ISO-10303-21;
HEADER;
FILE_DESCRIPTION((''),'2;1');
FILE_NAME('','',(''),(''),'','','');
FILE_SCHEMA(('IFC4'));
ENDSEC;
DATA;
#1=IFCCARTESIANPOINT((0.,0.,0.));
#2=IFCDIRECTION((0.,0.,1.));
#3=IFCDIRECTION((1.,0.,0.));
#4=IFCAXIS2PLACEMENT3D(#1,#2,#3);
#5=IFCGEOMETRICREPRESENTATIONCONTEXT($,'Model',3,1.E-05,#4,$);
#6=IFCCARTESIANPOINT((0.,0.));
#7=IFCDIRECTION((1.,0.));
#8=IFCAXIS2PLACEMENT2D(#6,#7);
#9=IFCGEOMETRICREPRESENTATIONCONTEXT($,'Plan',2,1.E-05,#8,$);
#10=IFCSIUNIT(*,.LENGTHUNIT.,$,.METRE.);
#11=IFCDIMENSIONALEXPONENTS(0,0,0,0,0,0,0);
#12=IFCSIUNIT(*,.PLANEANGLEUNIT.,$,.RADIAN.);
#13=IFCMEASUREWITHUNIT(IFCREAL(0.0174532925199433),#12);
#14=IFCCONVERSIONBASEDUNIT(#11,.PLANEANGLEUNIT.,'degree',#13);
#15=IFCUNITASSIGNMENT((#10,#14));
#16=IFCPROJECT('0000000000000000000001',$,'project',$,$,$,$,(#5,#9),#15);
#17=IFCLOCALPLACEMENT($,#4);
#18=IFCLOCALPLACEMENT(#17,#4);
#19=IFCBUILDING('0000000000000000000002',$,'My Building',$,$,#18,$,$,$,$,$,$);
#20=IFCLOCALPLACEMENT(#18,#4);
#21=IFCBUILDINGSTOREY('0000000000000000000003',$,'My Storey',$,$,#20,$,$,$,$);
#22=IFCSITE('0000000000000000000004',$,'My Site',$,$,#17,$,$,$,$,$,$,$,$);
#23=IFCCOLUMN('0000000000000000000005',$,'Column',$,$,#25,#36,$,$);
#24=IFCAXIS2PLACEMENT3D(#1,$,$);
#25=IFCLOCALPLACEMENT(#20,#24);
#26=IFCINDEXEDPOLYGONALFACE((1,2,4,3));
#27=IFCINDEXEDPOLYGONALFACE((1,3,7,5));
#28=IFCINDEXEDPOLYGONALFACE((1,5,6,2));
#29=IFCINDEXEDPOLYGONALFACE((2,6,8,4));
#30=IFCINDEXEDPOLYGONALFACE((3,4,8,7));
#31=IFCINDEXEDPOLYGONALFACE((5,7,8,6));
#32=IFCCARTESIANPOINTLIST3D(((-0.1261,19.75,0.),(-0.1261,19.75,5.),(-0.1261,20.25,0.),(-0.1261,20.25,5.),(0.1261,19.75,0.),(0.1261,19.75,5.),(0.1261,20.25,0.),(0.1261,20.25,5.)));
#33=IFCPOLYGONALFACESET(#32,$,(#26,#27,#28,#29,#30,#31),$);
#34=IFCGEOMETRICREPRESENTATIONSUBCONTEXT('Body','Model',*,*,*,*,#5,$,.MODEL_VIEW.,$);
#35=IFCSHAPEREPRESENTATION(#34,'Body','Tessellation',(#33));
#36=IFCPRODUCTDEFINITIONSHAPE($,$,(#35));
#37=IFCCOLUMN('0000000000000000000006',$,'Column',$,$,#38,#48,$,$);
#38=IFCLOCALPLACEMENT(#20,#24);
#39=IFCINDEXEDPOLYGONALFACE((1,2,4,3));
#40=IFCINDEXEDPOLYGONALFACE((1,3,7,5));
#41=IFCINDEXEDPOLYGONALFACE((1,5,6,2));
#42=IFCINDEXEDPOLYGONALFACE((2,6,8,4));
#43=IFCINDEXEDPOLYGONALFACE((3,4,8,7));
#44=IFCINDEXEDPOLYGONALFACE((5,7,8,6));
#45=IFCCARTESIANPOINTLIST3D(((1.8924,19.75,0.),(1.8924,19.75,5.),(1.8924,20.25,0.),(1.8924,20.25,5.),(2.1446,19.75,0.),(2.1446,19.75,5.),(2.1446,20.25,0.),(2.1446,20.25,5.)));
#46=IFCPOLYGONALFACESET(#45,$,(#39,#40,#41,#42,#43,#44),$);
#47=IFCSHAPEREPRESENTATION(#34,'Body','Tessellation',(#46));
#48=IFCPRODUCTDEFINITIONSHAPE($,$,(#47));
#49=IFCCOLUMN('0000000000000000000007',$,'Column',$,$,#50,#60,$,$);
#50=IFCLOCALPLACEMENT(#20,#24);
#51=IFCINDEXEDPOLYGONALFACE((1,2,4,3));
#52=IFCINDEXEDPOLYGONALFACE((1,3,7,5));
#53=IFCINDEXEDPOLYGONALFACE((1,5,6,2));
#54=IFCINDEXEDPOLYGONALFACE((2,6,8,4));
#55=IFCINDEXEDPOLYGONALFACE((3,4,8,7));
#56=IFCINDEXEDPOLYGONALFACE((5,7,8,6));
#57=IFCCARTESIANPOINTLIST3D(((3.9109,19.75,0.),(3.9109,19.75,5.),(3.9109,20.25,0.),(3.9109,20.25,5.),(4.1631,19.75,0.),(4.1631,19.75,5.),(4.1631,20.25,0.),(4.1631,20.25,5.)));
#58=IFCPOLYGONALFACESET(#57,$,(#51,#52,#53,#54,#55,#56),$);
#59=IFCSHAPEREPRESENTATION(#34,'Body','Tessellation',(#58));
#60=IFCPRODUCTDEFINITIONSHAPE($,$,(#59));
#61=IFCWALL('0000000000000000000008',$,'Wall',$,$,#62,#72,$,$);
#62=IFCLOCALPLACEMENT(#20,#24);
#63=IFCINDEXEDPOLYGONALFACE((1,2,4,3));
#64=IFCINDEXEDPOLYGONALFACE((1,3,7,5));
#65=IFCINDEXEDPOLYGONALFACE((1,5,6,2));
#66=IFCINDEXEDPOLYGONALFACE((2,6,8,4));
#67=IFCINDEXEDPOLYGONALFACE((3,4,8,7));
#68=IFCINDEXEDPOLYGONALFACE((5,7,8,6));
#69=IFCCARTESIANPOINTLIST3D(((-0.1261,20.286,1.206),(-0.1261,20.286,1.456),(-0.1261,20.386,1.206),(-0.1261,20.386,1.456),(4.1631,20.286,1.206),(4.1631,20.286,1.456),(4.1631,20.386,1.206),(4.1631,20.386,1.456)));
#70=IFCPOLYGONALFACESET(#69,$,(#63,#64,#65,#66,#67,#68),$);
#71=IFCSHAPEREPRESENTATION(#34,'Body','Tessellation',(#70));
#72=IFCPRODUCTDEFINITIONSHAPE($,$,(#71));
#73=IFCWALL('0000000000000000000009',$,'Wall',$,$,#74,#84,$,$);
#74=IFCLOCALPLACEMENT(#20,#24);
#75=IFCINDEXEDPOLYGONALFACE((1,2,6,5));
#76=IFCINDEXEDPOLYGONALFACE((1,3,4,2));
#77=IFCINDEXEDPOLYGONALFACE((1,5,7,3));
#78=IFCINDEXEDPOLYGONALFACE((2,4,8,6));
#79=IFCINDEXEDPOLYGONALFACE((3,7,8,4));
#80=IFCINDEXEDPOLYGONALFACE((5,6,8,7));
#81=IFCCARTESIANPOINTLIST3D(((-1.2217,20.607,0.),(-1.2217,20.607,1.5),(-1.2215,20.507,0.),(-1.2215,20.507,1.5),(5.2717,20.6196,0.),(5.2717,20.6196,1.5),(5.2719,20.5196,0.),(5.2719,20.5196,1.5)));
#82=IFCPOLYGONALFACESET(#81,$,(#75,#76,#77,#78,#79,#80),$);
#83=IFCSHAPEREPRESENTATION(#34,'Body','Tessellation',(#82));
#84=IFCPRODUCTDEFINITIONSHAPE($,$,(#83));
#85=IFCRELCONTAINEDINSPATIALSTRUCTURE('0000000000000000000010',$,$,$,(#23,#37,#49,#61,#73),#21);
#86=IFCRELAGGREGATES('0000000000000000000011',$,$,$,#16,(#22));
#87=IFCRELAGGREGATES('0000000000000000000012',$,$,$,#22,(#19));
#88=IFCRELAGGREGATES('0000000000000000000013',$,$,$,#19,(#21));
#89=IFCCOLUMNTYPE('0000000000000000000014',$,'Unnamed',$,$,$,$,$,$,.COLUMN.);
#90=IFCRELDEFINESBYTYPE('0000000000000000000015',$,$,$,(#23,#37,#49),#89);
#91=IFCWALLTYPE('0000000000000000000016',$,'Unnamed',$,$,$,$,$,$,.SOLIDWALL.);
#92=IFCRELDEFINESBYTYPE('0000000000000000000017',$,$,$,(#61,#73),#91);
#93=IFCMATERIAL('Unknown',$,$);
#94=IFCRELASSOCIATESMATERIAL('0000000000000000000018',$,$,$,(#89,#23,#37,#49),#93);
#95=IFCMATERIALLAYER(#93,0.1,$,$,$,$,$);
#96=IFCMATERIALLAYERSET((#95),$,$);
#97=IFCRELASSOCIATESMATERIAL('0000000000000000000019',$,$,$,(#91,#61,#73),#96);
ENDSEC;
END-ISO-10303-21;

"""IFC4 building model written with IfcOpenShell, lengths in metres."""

from ifc_helpers import new_model, entity, si_unit, converted_unit, frame, origin_with_axes, origin_2d_with_axis, place, context, subcontext, project, spatial, line, indexed_curve, outline, extrude, material, layer, layer_set, layer_usage, material_profile, profile_set, profile_usage, type_object, element, save


model = new_model("IFC4")

# Units and contexts
model_context = context("Model", 3, precision=1e-05, world=origin_with_axes())
plan_context = context("Plan", 2, precision=1e-05, world=origin_2d_with_axis())
body_context = subcontext(model_context, "Body", "Model", "MODEL_VIEW")
ifc_project = project(units=[si_unit("LENGTHUNIT", "METRE"), converted_unit("PLANEANGLEUNIT", "degree", entity("IfcReal", 0.0174532925199433), si_unit("PLANEANGLEUNIT", "RADIAN"), dimensions=[0, 0, 0, 0, 0, 0, 0])], contexts=[model_context, plan_context])

# Site, building, storey
site_placement = place(None, origin_with_axes())
site = spatial("IfcSite", under=ifc_project, at=site_placement, Name="My Site")
building_placement = place(site_placement, origin_with_axes())
building = spatial("IfcBuilding", under=site, at=building_placement, Name="My Building")
storey_placement = place(building_placement, origin_with_axes())
storey = spatial("IfcBuildingStorey", under=building, at=storey_placement, Name="My Storey")

# Columns
ifc_material = material(Name="Unknown")
ifc_material_profile = material_profile(ifc_material, outline(indexed_curve([(-0.1261, -0.25), (0.1261, -0.25), (0.1261, 0.25), (-0.1261, 0.25), (-0.1261, -0.25)])))
ifc_profile_set = profile_set([ifc_material_profile])
ifc_profile_usage_1 = profile_usage(ifc_profile_set, cardinal=5)
column_type = type_object("IfcColumnType", Name="Unnamed", PredefinedType="COLUMN", material=ifc_profile_set)
column_1_placement = place(storey_placement, frame((0.0, 20.0, 0.0), z_axis=(0.0, 0.0, 1.0), x_axis=(1.0, 0.0, 0.0)))
element("IfcColumn", 1, at=column_1_placement, inside=storey, type_object=column_type, material=ifc_profile_usage_1, Name="Column", context=body_context, shape_type="SweptSolid", body=[
    extrude(outline(indexed_curve([(-0.1261, -0.25), (0.1261, -0.25), (0.1261, 0.25), (-0.1261, 0.25), (-0.1261, -0.25)])), origin_with_axes(), (0.0, 0.0, 1.0), 5.0),
])
ifc_profile_usage_2 = profile_usage(ifc_profile_set, cardinal=5)
column_2_placement = place(storey_placement, frame((2.0185, 20.0, 0.0), z_axis=(0.0, 0.0, 1.0), x_axis=(1.0, 0.0, 0.0)))
element("IfcColumn", 2, at=column_2_placement, inside=storey, type_object=column_type, material=ifc_profile_usage_2, Name="Column", context=body_context, shape_type="SweptSolid", body=[
    extrude(outline(indexed_curve([(-0.1261, -0.25), (0.1261, -0.25), (0.1261, 0.25), (-0.1261, 0.25), (-0.1261, -0.25)])), origin_with_axes(), (0.0, 0.0, 1.0), 5.0),
])
ifc_profile_usage_3 = profile_usage(ifc_profile_set, cardinal=5)
column_3_placement = place(storey_placement, frame((4.037, 20.0, 0.0), z_axis=(0.0, 0.0, 1.0), x_axis=(1.0, 0.0, 0.0)))
element("IfcColumn", 3, at=column_3_placement, inside=storey, type_object=column_type, material=ifc_profile_usage_3, Name="Column", context=body_context, shape_type="SweptSolid", body=[
    extrude(outline(indexed_curve([(-0.1261, -0.25), (0.1261, -0.25), (0.1261, 0.25), (-0.1261, 0.25), (-0.1261, -0.25)])), origin_with_axes(), (0.0, 0.0, 1.0), 5.0),
])

# Walls
ifc_layer_1 = layer(ifc_material, 0.1)
ifc_layer_set_1 = layer_set([ifc_layer_1])
ifc_layer_usage_1 = layer_usage(ifc_layer_set_1, "AXIS2", "POSITIVE", 0.0)
wall_type = type_object("IfcWallType", Name="Unnamed", PredefinedType="SOLIDWALL", material=ifc_layer_set_1)
wall_1_placement = place(storey_placement, frame((4.1631, 20.386, 1.206), z_axis=(0.0, 0.0, 1.0), x_axis=(-1.0, 0.0, 0.0)))
element("IfcWall", 4, at=wall_1_placement, inside=storey, type_object=wall_type, material=ifc_layer_usage_1, Name="Wall", context=body_context, shape_type="SweptSolid", body=[
    extrude(outline(indexed_curve([(0.0, 0.0), (0.0, 0.1), (4.2892, 0.1), (4.2892, 0.0)], segments=[line(1, 2, 3, 4, 1)])), origin_with_axes(), (0.0, 0.0, 1.0), 0.25),
])
ifc_layer_usage_2 = layer_usage(ifc_layer_set_1, "AXIS2", "POSITIVE", 0.0)
wall_2_placement = place(storey_placement, frame((5.2717, 20.6196, 0.0), z_axis=(0.0, 0.0, 1.0), x_axis=(-0.999998, -0.001942, 0.0)))
element("IfcWall", 5, at=wall_2_placement, inside=storey, type_object=wall_type, material=ifc_layer_usage_2, Name="Wall", context=body_context, shape_type="SweptSolid", body=[
    extrude(outline(indexed_curve([(0.0, 0.0), (0.0, 0.1), (6.4934, 0.1), (6.4934, 0.0)], segments=[line(1, 2, 3, 4, 1)])), origin_with_axes(), (0.0, 0.0, 1.0), 1.5),
])

save(model, "model.ifc")
